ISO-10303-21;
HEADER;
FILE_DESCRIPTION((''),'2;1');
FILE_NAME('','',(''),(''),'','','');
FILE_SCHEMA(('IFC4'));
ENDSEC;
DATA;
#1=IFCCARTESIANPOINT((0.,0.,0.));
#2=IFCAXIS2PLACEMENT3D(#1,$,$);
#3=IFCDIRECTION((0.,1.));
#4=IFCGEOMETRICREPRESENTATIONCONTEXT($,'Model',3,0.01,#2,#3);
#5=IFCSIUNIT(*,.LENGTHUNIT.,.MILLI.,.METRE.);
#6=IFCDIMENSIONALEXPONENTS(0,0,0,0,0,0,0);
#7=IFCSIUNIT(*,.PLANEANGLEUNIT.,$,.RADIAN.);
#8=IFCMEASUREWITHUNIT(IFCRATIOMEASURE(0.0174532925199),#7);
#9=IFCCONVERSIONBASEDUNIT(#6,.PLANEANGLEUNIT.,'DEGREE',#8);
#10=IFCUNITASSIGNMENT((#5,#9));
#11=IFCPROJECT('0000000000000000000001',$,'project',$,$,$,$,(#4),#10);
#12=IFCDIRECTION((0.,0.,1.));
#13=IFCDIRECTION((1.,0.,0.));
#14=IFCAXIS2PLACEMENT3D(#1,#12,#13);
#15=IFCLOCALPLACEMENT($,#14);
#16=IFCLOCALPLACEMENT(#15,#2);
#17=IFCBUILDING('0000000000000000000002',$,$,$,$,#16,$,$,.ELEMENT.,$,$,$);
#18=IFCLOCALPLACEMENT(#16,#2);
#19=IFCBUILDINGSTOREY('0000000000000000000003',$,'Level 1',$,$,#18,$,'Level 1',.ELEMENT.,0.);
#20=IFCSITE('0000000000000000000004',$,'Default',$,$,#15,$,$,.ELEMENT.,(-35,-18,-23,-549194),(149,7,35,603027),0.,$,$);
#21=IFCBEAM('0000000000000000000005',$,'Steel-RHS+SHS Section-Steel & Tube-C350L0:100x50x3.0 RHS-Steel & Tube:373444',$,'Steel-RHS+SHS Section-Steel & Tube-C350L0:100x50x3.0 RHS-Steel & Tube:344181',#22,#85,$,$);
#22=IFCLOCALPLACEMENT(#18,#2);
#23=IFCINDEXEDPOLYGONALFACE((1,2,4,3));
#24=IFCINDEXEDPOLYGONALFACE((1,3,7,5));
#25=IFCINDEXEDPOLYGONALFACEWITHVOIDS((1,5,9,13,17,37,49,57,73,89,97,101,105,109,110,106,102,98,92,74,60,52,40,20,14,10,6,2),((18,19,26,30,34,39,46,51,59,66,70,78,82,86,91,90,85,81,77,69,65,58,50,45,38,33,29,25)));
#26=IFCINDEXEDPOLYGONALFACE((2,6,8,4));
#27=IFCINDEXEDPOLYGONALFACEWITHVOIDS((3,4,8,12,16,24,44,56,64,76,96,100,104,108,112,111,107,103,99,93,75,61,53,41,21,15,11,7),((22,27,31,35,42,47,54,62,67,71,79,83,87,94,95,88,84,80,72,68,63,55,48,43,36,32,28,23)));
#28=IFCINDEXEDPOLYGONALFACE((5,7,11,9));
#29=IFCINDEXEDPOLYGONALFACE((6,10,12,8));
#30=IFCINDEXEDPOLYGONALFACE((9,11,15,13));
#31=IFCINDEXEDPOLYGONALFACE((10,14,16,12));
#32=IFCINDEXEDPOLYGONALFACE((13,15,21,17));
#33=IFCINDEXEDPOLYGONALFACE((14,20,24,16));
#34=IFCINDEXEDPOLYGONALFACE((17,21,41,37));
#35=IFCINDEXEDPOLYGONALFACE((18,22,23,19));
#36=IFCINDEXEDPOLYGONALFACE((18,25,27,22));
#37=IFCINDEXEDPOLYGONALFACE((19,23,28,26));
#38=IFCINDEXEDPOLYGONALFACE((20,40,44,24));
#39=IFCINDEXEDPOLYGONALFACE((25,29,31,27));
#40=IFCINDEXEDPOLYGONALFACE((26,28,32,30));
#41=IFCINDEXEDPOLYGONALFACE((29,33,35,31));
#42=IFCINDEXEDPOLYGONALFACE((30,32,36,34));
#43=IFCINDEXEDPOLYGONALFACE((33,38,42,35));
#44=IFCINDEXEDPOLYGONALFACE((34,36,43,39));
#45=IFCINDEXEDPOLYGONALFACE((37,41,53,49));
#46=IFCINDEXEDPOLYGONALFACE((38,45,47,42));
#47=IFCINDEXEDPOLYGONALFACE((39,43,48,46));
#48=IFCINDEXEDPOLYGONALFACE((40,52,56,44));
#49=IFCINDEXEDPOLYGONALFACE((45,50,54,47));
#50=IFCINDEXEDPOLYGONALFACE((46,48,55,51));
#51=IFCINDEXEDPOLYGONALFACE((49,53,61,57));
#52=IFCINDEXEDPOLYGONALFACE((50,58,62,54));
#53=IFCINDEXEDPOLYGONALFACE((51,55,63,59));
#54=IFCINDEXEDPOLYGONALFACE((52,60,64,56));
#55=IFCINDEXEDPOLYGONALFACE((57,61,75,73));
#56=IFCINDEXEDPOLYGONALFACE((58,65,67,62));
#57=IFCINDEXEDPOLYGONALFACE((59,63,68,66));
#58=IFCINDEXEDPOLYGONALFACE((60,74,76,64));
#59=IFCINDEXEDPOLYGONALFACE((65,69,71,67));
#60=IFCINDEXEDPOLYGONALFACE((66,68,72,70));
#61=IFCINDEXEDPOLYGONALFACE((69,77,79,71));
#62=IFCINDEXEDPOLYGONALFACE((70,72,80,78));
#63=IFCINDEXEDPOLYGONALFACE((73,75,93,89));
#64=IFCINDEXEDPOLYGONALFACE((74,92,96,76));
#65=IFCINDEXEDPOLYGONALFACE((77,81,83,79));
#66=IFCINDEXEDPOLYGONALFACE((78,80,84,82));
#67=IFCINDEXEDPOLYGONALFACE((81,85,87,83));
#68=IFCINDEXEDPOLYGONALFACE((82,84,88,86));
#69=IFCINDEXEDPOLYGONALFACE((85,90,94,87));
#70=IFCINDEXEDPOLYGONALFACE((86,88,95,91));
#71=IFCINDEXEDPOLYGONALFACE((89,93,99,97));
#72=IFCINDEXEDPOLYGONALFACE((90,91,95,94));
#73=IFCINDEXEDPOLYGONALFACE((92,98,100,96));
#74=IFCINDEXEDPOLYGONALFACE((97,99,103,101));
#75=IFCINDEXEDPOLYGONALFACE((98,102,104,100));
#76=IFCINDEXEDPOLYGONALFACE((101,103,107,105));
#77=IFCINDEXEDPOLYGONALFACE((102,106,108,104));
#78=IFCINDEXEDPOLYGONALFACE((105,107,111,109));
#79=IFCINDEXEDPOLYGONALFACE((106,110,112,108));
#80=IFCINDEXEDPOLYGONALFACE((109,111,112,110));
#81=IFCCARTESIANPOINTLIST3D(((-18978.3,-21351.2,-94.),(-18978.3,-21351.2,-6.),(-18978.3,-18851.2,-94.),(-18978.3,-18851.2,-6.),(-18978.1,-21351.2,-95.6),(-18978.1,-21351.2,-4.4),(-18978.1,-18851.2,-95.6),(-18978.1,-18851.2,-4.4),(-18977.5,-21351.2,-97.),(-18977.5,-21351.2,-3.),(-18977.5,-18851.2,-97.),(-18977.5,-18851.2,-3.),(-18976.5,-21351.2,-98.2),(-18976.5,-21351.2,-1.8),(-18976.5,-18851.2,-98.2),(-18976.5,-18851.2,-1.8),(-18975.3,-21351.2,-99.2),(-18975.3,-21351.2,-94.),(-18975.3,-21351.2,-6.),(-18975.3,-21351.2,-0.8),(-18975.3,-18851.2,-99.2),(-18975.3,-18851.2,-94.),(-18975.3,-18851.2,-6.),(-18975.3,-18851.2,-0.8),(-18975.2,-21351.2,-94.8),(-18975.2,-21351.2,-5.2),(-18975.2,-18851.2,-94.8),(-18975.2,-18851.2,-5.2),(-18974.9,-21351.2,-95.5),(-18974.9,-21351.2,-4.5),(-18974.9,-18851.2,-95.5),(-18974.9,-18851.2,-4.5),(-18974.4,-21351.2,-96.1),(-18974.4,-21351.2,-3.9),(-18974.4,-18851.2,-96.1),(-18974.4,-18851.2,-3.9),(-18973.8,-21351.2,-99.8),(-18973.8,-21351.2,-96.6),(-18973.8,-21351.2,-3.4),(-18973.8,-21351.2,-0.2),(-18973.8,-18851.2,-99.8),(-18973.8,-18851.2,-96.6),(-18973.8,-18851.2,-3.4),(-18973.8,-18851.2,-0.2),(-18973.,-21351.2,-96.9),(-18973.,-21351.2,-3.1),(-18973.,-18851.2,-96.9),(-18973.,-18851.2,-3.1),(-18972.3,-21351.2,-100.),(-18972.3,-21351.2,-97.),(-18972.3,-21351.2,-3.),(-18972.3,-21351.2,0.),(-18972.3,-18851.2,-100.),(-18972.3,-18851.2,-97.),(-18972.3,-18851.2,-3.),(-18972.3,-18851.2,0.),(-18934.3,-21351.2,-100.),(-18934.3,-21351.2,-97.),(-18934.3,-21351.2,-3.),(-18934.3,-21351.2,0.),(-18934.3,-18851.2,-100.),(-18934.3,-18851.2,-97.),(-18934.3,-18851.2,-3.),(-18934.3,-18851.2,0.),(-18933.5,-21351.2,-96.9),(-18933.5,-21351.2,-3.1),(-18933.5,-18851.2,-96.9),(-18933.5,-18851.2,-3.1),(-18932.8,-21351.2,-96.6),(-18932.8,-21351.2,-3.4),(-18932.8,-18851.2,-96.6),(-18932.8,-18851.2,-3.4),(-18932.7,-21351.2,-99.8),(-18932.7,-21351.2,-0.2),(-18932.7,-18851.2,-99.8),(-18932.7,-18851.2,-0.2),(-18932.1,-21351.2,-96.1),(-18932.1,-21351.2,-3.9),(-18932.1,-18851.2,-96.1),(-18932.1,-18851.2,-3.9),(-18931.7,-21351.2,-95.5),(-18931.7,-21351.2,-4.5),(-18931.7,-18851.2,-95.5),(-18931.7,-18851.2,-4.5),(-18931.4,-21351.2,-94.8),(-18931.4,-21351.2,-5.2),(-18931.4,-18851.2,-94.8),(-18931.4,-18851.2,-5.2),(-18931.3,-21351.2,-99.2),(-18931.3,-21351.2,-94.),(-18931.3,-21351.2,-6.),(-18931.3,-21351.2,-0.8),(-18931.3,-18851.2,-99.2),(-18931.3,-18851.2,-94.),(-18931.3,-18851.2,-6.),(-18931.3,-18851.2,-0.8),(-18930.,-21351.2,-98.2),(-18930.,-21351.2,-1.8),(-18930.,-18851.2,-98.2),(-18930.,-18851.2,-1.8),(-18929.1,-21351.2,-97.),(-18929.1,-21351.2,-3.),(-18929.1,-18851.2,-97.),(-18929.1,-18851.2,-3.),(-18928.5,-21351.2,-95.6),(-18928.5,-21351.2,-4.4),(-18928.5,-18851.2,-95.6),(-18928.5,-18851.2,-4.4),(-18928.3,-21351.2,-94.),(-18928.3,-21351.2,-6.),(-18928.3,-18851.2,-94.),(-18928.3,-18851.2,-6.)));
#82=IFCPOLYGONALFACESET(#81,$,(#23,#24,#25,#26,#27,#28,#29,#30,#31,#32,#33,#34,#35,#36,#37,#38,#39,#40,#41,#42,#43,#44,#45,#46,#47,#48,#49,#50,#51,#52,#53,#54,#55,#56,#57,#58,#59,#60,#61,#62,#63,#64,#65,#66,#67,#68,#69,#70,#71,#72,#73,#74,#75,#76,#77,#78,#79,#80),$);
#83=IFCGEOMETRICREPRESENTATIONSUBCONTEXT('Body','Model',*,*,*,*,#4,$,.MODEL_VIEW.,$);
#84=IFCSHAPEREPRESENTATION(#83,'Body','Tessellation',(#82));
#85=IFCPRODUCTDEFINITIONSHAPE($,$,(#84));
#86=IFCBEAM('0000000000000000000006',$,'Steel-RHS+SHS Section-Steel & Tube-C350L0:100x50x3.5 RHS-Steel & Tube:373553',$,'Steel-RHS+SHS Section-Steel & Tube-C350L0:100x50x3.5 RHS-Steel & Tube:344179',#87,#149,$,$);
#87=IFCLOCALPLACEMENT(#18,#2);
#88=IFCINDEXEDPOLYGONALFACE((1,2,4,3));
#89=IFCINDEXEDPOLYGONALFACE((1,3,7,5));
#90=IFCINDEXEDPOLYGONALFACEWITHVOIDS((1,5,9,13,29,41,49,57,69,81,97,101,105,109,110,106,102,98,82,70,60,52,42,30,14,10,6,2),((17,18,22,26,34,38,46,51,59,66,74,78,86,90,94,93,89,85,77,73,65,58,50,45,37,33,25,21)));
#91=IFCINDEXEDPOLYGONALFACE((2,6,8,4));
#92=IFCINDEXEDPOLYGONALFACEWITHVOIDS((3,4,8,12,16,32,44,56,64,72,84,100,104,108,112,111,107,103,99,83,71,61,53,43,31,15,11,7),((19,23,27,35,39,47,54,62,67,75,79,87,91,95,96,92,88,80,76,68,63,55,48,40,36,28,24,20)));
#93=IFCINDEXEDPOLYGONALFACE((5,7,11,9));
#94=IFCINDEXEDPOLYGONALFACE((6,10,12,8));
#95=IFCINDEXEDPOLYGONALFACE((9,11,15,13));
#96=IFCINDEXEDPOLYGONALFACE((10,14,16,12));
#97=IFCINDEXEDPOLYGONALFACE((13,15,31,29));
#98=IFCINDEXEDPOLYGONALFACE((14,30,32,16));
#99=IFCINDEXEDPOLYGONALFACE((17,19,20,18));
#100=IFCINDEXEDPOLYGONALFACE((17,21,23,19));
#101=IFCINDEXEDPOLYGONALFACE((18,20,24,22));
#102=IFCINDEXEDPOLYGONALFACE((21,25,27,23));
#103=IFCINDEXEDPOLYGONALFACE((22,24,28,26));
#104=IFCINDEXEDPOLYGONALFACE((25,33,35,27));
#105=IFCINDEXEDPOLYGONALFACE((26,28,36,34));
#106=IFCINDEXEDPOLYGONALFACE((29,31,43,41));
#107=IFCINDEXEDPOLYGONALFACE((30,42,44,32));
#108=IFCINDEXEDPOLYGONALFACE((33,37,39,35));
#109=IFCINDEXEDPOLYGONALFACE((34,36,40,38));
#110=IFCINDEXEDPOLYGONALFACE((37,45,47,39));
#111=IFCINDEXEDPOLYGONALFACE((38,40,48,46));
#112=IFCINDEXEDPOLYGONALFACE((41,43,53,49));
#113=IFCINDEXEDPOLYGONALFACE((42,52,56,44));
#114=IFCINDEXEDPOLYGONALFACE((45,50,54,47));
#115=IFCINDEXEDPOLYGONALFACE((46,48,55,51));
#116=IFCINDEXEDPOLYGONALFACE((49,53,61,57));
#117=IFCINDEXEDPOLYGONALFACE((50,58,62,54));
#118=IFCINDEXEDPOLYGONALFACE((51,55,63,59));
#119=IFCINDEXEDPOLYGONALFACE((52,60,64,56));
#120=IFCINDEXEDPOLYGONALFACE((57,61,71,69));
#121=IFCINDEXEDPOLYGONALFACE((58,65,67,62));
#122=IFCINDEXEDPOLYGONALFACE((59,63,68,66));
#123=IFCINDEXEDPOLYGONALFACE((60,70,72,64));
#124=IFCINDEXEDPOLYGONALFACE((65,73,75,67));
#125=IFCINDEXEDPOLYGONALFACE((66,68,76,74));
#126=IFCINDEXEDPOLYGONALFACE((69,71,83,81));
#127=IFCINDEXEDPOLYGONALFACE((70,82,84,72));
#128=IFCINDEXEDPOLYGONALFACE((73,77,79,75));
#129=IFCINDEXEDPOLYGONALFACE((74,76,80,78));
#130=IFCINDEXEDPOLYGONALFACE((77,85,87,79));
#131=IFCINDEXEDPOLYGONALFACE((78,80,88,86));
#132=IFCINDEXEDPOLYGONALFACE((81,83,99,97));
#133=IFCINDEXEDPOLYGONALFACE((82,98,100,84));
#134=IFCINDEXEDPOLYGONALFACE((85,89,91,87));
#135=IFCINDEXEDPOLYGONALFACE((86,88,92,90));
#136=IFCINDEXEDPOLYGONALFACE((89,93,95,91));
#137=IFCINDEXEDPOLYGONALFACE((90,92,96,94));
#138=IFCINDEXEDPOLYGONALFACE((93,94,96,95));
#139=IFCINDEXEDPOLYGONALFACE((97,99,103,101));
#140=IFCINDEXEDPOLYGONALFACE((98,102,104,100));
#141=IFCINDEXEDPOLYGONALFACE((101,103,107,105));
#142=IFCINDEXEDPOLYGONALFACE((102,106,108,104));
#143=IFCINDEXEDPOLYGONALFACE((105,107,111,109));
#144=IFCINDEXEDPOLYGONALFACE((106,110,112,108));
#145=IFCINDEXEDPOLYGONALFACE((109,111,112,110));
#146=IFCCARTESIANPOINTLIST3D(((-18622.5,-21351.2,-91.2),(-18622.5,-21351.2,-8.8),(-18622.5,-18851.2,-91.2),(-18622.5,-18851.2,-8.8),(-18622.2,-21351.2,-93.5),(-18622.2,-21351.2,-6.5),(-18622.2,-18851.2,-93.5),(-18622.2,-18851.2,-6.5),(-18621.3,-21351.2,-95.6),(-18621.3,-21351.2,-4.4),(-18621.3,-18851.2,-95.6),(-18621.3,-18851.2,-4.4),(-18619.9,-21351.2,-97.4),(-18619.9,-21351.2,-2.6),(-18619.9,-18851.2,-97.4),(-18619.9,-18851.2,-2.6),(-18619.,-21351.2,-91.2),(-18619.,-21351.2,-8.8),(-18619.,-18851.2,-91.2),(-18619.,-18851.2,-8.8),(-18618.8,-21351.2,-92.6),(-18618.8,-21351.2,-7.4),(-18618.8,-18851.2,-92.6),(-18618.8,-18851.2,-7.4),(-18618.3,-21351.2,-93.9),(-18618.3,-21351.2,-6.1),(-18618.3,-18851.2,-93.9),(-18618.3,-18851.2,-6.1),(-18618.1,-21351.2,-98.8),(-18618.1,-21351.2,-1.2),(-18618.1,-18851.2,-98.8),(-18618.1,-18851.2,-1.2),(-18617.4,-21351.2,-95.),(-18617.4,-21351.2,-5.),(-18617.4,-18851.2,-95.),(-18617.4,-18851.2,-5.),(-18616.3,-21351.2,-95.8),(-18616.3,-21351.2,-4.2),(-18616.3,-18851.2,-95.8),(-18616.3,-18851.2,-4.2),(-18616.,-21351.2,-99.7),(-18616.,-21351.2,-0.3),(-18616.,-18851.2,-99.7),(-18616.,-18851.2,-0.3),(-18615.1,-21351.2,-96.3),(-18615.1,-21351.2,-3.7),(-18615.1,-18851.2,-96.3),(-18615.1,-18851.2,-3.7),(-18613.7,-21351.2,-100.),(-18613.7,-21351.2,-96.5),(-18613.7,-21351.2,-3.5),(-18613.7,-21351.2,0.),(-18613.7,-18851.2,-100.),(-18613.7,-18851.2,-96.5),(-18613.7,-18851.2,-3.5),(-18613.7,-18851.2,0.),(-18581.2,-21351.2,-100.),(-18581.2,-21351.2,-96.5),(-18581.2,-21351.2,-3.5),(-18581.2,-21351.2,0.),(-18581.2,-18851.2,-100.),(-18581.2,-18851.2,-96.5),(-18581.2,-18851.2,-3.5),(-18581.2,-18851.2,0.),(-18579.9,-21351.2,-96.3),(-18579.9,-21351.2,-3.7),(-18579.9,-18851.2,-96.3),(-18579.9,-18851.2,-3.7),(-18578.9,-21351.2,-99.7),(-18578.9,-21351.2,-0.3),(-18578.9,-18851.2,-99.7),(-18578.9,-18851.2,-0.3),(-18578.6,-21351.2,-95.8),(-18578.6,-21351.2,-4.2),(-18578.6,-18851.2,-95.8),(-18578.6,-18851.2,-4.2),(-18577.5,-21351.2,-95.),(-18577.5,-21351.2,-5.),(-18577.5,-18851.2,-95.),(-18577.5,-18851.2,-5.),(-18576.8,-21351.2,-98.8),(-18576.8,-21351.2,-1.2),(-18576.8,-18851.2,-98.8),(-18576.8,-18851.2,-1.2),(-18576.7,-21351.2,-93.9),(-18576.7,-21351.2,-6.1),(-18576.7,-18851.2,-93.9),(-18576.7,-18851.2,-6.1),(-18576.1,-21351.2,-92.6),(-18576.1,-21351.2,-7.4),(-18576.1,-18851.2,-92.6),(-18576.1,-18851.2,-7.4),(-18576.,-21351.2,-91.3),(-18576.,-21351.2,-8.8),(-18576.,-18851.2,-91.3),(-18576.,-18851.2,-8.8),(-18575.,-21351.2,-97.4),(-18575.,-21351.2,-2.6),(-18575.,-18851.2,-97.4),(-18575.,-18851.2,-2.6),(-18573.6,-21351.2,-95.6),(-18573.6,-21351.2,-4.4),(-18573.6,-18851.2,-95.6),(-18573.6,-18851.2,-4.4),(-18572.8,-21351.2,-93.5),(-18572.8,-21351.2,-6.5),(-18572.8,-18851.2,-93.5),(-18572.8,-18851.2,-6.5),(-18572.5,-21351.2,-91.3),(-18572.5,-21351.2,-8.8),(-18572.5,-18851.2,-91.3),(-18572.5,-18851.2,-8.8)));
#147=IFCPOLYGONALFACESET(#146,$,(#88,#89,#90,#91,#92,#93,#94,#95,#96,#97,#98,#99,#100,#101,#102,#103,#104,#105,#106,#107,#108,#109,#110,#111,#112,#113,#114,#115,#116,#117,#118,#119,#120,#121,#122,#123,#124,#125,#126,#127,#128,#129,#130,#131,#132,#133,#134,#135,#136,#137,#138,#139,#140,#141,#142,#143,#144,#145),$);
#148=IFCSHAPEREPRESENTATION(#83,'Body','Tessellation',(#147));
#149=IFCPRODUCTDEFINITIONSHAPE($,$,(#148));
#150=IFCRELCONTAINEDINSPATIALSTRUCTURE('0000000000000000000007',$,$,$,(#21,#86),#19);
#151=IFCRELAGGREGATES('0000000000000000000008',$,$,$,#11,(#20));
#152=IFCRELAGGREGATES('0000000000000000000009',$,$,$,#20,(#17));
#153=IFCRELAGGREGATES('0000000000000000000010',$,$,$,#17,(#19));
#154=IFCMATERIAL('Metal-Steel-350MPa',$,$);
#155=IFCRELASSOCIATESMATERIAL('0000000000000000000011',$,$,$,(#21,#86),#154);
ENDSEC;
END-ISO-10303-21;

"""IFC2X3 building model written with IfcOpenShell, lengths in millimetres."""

from ifc_helpers import new_model, entity, si_unit, converted_unit, direction, frame, frame_2d, origin, origin_with_axes, place, context, subcontext, project, spatial, polyline, circle_curve, parameter, trimmed, segment, composite_curve, outline, extrude, material, element, save


model = new_model("IFC2X3")

# Units and contexts
model_context = context("Model", 3, precision=0.01, world=origin(), true_north=direction((0.0, 1.0)))
body_context = subcontext(model_context, "Body", "Model", "MODEL_VIEW")
ifc_project = project(units=[si_unit("LENGTHUNIT", "METRE", prefix="MILLI"), converted_unit("PLANEANGLEUNIT", "DEGREE", entity("IfcRatioMeasure", 0.0174532925199), si_unit("PLANEANGLEUNIT", "RADIAN"), dimensions=[0, 0, 0, 0, 0, 0, 0])], contexts=[model_context])

# Site, building, storey
site_placement = place(None, origin_with_axes())
site = spatial("IfcSite", under=ifc_project, at=site_placement, Name="Default", CompositionType="ELEMENT", RefLatitude=(-35, -18, -23, -549194), RefLongitude=(149, 7, 35, 603027), RefElevation=0.0)
building_placement = place(site_placement, origin())
building = spatial("IfcBuilding", under=site, at=building_placement, CompositionType="ELEMENT")
storey_placement = place(building_placement, origin())
storey = spatial("IfcBuildingStorey", under=building, at=storey_placement, Name="Level 1", LongName="Level 1", CompositionType="ELEMENT", Elevation=0.0)

# Beams
ifc_material = material(Name="Metal-Steel-350MPa")
beam_1_placement = place(storey_placement, frame((-18953.3, -18851.2, 0.0), z_axis=(0.0, 0.0, 1.0), x_axis=(0.0, -1.0, 0.0)))
element("IfcBeam", 1, at=beam_1_placement, inside=storey, material=ifc_material, Name="Steel-RHS+SHS Section-Steel & Tube-C350L0:100x50x3.0 RHS-Steel & Tube:373444", ObjectType="Steel-RHS+SHS Section-Steel & Tube-C350L0:100x50x3.0 RHS-Steel & Tube:344181", context=body_context, shape_type="SweptSolid", body=[
    extrude(outline(composite_curve([segment(trimmed(circle_curve(frame_2d((-19.0, -44.0), x_axis=(1.0, 0.0)), 6.0), [parameter(180.0)], [parameter(270.0)], True, "PARAMETER"), True, "CONTINUOUS"), segment(polyline([(-19.0, -50.0), (19.0, -50.0)]), True, "CONTINUOUS"), segment(trimmed(circle_curve(frame_2d((19.0, -44.0), x_axis=(1.0, 0.0)), 6.0), [parameter(270.0)], [parameter(0.0)], True, "PARAMETER"), True, "CONTINUOUS"), segment(polyline([(25.0, -44.0), (25.0, 44.0)]), True, "CONTINUOUS"), segment(trimmed(circle_curve(frame_2d((19.0, 44.0), x_axis=(1.0, 0.0)), 6.0), [parameter(0.0)], [parameter(90.0)], True, "PARAMETER"), True, "CONTINUOUS"), segment(polyline([(19.0, 50.0), (-19.0, 50.0)]), True, "CONTINUOUS"), segment(trimmed(circle_curve(frame_2d((-19.0, 44.0), x_axis=(1.0, 0.0)), 6.0), [parameter(90.0)], [parameter(180.0)], True, "PARAMETER"), True, "CONTINUOUS"), segment(polyline([(-25.0, 44.0), (-25.0, -44.0)]), True, "CONTINUOUS")], self_intersect=False), holes=[composite_curve([segment(polyline([(19.0, -47.0), (-19.0, -47.0)]), True, "CONTINUOUS"), segment(trimmed(circle_curve(frame_2d((-19.0, -44.0), x_axis=(1.0, 0.0)), 3.0), [parameter(180.0)], [parameter(270.0)], True, "PARAMETER"), False, "CONTINUOUS"), segment(polyline([(-22.0, -44.0), (-22.0, 44.0)]), True, "CONTINUOUS"), segment(trimmed(circle_curve(frame_2d((-19.0, 44.0), x_axis=(1.0, 0.0)), 3.0), [parameter(90.0)], [parameter(180.0)], True, "PARAMETER"), False, "CONTINUOUS"), segment(polyline([(-19.0, 47.0), (19.0, 47.0)]), True, "CONTINUOUS"), segment(trimmed(circle_curve(frame_2d((19.0, 44.0), x_axis=(1.0, 0.0)), 3.0), [parameter(360.0)], [parameter(90.0)], True, "PARAMETER"), False, "CONTINUOUS"), segment(polyline([(22.0, 44.0), (22.0, -44.0)]), True, "CONTINUOUS"), segment(trimmed(circle_curve(frame_2d((19.0, -44.0), x_axis=(1.0, 0.0)), 3.0), [parameter(270.0)], [parameter(360.0)], True, "PARAMETER"), False, "CONTINUOUS")], self_intersect=False)]), frame((0.0, 0.0, -50.0), z_axis=(1.0, 0.0, 0.0), x_axis=(0.0, -1.0, 0.0)), (0.0, 0.0, 1.0), 2500.0),
])
beam_2_placement = place(storey_placement, frame((-18597.5, -18851.2, 0.0), z_axis=(0.0, 0.0, 1.0), x_axis=(0.0, -1.0, 0.0)))
element("IfcBeam", 2, at=beam_2_placement, inside=storey, material=ifc_material, Name="Steel-RHS+SHS Section-Steel & Tube-C350L0:100x50x3.5 RHS-Steel & Tube:373553", ObjectType="Steel-RHS+SHS Section-Steel & Tube-C350L0:100x50x3.5 RHS-Steel & Tube:344179", context=body_context, shape_type="SweptSolid", body=[
    extrude(outline(composite_curve([segment(trimmed(circle_curve(frame_2d((-16.2, -41.2), x_axis=(1.0, 0.0)), 8.8), [parameter(180.0)], [parameter(270.0)], True, "PARAMETER"), True, "CONTINUOUS"), segment(polyline([(-16.2, -50.0), (16.2, -50.0)]), True, "CONTINUOUS"), segment(trimmed(circle_curve(frame_2d((16.2, -41.2), x_axis=(1.0, 0.0)), 8.8), [parameter(270.0)], [parameter(0.0)], True, "PARAMETER"), True, "CONTINUOUS"), segment(polyline([(25.0, -41.2), (25.0, 41.2)]), True, "CONTINUOUS"), segment(trimmed(circle_curve(frame_2d((16.2, 41.2), x_axis=(1.0, 0.0)), 8.8), [parameter(0.0)], [parameter(90.0)], True, "PARAMETER"), True, "CONTINUOUS"), segment(polyline([(16.2, 50.0), (-16.2, 50.0)]), True, "CONTINUOUS"), segment(trimmed(circle_curve(frame_2d((-16.2, 41.2), x_axis=(1.0, 0.0)), 8.8), [parameter(90.0)], [parameter(180.0)], True, "PARAMETER"), True, "CONTINUOUS"), segment(polyline([(-25.0, 41.2), (-25.0, -41.2)]), True, "CONTINUOUS")], self_intersect=False), holes=[composite_curve([segment(polyline([(16.2, -46.5), (-16.2, -46.5)]), True, "CONTINUOUS"), segment(trimmed(circle_curve(frame_2d((-16.2, -41.2), x_axis=(1.0, 0.0)), 5.2), [parameter(180.0)], [parameter(270.0)], True, "PARAMETER"), False, "CONTINUOUS"), segment(polyline([(-21.5, -41.2), (-21.5, 41.2)]), True, "CONTINUOUS"), segment(trimmed(circle_curve(frame_2d((-16.2, 41.2), x_axis=(1.0, 0.0)), 5.2), [parameter(90.0)], [parameter(180.0)], True, "PARAMETER"), False, "CONTINUOUS"), segment(polyline([(-16.2, 46.5), (16.2, 46.5)]), True, "CONTINUOUS"), segment(trimmed(circle_curve(frame_2d((16.2, 41.2), x_axis=(1.0, 0.0)), 5.2), [parameter(360.0)], [parameter(90.0)], True, "PARAMETER"), False, "CONTINUOUS"), segment(polyline([(21.5, 41.2), (21.5, -41.2)]), True, "CONTINUOUS"), segment(trimmed(circle_curve(frame_2d((16.2, -41.2), x_axis=(1.0, 0.0)), 5.2), [parameter(270.0)], [parameter(0.0)], True, "PARAMETER"), False, "CONTINUOUS")], self_intersect=False)]), frame((0.0, 0.0, -50.0), z_axis=(1.0, 0.0, 0.0), x_axis=(0.0, -1.0, 0.0)), (0.0, 0.0, 1.0), 2500.0),
])

save(model, "model.ifc")
